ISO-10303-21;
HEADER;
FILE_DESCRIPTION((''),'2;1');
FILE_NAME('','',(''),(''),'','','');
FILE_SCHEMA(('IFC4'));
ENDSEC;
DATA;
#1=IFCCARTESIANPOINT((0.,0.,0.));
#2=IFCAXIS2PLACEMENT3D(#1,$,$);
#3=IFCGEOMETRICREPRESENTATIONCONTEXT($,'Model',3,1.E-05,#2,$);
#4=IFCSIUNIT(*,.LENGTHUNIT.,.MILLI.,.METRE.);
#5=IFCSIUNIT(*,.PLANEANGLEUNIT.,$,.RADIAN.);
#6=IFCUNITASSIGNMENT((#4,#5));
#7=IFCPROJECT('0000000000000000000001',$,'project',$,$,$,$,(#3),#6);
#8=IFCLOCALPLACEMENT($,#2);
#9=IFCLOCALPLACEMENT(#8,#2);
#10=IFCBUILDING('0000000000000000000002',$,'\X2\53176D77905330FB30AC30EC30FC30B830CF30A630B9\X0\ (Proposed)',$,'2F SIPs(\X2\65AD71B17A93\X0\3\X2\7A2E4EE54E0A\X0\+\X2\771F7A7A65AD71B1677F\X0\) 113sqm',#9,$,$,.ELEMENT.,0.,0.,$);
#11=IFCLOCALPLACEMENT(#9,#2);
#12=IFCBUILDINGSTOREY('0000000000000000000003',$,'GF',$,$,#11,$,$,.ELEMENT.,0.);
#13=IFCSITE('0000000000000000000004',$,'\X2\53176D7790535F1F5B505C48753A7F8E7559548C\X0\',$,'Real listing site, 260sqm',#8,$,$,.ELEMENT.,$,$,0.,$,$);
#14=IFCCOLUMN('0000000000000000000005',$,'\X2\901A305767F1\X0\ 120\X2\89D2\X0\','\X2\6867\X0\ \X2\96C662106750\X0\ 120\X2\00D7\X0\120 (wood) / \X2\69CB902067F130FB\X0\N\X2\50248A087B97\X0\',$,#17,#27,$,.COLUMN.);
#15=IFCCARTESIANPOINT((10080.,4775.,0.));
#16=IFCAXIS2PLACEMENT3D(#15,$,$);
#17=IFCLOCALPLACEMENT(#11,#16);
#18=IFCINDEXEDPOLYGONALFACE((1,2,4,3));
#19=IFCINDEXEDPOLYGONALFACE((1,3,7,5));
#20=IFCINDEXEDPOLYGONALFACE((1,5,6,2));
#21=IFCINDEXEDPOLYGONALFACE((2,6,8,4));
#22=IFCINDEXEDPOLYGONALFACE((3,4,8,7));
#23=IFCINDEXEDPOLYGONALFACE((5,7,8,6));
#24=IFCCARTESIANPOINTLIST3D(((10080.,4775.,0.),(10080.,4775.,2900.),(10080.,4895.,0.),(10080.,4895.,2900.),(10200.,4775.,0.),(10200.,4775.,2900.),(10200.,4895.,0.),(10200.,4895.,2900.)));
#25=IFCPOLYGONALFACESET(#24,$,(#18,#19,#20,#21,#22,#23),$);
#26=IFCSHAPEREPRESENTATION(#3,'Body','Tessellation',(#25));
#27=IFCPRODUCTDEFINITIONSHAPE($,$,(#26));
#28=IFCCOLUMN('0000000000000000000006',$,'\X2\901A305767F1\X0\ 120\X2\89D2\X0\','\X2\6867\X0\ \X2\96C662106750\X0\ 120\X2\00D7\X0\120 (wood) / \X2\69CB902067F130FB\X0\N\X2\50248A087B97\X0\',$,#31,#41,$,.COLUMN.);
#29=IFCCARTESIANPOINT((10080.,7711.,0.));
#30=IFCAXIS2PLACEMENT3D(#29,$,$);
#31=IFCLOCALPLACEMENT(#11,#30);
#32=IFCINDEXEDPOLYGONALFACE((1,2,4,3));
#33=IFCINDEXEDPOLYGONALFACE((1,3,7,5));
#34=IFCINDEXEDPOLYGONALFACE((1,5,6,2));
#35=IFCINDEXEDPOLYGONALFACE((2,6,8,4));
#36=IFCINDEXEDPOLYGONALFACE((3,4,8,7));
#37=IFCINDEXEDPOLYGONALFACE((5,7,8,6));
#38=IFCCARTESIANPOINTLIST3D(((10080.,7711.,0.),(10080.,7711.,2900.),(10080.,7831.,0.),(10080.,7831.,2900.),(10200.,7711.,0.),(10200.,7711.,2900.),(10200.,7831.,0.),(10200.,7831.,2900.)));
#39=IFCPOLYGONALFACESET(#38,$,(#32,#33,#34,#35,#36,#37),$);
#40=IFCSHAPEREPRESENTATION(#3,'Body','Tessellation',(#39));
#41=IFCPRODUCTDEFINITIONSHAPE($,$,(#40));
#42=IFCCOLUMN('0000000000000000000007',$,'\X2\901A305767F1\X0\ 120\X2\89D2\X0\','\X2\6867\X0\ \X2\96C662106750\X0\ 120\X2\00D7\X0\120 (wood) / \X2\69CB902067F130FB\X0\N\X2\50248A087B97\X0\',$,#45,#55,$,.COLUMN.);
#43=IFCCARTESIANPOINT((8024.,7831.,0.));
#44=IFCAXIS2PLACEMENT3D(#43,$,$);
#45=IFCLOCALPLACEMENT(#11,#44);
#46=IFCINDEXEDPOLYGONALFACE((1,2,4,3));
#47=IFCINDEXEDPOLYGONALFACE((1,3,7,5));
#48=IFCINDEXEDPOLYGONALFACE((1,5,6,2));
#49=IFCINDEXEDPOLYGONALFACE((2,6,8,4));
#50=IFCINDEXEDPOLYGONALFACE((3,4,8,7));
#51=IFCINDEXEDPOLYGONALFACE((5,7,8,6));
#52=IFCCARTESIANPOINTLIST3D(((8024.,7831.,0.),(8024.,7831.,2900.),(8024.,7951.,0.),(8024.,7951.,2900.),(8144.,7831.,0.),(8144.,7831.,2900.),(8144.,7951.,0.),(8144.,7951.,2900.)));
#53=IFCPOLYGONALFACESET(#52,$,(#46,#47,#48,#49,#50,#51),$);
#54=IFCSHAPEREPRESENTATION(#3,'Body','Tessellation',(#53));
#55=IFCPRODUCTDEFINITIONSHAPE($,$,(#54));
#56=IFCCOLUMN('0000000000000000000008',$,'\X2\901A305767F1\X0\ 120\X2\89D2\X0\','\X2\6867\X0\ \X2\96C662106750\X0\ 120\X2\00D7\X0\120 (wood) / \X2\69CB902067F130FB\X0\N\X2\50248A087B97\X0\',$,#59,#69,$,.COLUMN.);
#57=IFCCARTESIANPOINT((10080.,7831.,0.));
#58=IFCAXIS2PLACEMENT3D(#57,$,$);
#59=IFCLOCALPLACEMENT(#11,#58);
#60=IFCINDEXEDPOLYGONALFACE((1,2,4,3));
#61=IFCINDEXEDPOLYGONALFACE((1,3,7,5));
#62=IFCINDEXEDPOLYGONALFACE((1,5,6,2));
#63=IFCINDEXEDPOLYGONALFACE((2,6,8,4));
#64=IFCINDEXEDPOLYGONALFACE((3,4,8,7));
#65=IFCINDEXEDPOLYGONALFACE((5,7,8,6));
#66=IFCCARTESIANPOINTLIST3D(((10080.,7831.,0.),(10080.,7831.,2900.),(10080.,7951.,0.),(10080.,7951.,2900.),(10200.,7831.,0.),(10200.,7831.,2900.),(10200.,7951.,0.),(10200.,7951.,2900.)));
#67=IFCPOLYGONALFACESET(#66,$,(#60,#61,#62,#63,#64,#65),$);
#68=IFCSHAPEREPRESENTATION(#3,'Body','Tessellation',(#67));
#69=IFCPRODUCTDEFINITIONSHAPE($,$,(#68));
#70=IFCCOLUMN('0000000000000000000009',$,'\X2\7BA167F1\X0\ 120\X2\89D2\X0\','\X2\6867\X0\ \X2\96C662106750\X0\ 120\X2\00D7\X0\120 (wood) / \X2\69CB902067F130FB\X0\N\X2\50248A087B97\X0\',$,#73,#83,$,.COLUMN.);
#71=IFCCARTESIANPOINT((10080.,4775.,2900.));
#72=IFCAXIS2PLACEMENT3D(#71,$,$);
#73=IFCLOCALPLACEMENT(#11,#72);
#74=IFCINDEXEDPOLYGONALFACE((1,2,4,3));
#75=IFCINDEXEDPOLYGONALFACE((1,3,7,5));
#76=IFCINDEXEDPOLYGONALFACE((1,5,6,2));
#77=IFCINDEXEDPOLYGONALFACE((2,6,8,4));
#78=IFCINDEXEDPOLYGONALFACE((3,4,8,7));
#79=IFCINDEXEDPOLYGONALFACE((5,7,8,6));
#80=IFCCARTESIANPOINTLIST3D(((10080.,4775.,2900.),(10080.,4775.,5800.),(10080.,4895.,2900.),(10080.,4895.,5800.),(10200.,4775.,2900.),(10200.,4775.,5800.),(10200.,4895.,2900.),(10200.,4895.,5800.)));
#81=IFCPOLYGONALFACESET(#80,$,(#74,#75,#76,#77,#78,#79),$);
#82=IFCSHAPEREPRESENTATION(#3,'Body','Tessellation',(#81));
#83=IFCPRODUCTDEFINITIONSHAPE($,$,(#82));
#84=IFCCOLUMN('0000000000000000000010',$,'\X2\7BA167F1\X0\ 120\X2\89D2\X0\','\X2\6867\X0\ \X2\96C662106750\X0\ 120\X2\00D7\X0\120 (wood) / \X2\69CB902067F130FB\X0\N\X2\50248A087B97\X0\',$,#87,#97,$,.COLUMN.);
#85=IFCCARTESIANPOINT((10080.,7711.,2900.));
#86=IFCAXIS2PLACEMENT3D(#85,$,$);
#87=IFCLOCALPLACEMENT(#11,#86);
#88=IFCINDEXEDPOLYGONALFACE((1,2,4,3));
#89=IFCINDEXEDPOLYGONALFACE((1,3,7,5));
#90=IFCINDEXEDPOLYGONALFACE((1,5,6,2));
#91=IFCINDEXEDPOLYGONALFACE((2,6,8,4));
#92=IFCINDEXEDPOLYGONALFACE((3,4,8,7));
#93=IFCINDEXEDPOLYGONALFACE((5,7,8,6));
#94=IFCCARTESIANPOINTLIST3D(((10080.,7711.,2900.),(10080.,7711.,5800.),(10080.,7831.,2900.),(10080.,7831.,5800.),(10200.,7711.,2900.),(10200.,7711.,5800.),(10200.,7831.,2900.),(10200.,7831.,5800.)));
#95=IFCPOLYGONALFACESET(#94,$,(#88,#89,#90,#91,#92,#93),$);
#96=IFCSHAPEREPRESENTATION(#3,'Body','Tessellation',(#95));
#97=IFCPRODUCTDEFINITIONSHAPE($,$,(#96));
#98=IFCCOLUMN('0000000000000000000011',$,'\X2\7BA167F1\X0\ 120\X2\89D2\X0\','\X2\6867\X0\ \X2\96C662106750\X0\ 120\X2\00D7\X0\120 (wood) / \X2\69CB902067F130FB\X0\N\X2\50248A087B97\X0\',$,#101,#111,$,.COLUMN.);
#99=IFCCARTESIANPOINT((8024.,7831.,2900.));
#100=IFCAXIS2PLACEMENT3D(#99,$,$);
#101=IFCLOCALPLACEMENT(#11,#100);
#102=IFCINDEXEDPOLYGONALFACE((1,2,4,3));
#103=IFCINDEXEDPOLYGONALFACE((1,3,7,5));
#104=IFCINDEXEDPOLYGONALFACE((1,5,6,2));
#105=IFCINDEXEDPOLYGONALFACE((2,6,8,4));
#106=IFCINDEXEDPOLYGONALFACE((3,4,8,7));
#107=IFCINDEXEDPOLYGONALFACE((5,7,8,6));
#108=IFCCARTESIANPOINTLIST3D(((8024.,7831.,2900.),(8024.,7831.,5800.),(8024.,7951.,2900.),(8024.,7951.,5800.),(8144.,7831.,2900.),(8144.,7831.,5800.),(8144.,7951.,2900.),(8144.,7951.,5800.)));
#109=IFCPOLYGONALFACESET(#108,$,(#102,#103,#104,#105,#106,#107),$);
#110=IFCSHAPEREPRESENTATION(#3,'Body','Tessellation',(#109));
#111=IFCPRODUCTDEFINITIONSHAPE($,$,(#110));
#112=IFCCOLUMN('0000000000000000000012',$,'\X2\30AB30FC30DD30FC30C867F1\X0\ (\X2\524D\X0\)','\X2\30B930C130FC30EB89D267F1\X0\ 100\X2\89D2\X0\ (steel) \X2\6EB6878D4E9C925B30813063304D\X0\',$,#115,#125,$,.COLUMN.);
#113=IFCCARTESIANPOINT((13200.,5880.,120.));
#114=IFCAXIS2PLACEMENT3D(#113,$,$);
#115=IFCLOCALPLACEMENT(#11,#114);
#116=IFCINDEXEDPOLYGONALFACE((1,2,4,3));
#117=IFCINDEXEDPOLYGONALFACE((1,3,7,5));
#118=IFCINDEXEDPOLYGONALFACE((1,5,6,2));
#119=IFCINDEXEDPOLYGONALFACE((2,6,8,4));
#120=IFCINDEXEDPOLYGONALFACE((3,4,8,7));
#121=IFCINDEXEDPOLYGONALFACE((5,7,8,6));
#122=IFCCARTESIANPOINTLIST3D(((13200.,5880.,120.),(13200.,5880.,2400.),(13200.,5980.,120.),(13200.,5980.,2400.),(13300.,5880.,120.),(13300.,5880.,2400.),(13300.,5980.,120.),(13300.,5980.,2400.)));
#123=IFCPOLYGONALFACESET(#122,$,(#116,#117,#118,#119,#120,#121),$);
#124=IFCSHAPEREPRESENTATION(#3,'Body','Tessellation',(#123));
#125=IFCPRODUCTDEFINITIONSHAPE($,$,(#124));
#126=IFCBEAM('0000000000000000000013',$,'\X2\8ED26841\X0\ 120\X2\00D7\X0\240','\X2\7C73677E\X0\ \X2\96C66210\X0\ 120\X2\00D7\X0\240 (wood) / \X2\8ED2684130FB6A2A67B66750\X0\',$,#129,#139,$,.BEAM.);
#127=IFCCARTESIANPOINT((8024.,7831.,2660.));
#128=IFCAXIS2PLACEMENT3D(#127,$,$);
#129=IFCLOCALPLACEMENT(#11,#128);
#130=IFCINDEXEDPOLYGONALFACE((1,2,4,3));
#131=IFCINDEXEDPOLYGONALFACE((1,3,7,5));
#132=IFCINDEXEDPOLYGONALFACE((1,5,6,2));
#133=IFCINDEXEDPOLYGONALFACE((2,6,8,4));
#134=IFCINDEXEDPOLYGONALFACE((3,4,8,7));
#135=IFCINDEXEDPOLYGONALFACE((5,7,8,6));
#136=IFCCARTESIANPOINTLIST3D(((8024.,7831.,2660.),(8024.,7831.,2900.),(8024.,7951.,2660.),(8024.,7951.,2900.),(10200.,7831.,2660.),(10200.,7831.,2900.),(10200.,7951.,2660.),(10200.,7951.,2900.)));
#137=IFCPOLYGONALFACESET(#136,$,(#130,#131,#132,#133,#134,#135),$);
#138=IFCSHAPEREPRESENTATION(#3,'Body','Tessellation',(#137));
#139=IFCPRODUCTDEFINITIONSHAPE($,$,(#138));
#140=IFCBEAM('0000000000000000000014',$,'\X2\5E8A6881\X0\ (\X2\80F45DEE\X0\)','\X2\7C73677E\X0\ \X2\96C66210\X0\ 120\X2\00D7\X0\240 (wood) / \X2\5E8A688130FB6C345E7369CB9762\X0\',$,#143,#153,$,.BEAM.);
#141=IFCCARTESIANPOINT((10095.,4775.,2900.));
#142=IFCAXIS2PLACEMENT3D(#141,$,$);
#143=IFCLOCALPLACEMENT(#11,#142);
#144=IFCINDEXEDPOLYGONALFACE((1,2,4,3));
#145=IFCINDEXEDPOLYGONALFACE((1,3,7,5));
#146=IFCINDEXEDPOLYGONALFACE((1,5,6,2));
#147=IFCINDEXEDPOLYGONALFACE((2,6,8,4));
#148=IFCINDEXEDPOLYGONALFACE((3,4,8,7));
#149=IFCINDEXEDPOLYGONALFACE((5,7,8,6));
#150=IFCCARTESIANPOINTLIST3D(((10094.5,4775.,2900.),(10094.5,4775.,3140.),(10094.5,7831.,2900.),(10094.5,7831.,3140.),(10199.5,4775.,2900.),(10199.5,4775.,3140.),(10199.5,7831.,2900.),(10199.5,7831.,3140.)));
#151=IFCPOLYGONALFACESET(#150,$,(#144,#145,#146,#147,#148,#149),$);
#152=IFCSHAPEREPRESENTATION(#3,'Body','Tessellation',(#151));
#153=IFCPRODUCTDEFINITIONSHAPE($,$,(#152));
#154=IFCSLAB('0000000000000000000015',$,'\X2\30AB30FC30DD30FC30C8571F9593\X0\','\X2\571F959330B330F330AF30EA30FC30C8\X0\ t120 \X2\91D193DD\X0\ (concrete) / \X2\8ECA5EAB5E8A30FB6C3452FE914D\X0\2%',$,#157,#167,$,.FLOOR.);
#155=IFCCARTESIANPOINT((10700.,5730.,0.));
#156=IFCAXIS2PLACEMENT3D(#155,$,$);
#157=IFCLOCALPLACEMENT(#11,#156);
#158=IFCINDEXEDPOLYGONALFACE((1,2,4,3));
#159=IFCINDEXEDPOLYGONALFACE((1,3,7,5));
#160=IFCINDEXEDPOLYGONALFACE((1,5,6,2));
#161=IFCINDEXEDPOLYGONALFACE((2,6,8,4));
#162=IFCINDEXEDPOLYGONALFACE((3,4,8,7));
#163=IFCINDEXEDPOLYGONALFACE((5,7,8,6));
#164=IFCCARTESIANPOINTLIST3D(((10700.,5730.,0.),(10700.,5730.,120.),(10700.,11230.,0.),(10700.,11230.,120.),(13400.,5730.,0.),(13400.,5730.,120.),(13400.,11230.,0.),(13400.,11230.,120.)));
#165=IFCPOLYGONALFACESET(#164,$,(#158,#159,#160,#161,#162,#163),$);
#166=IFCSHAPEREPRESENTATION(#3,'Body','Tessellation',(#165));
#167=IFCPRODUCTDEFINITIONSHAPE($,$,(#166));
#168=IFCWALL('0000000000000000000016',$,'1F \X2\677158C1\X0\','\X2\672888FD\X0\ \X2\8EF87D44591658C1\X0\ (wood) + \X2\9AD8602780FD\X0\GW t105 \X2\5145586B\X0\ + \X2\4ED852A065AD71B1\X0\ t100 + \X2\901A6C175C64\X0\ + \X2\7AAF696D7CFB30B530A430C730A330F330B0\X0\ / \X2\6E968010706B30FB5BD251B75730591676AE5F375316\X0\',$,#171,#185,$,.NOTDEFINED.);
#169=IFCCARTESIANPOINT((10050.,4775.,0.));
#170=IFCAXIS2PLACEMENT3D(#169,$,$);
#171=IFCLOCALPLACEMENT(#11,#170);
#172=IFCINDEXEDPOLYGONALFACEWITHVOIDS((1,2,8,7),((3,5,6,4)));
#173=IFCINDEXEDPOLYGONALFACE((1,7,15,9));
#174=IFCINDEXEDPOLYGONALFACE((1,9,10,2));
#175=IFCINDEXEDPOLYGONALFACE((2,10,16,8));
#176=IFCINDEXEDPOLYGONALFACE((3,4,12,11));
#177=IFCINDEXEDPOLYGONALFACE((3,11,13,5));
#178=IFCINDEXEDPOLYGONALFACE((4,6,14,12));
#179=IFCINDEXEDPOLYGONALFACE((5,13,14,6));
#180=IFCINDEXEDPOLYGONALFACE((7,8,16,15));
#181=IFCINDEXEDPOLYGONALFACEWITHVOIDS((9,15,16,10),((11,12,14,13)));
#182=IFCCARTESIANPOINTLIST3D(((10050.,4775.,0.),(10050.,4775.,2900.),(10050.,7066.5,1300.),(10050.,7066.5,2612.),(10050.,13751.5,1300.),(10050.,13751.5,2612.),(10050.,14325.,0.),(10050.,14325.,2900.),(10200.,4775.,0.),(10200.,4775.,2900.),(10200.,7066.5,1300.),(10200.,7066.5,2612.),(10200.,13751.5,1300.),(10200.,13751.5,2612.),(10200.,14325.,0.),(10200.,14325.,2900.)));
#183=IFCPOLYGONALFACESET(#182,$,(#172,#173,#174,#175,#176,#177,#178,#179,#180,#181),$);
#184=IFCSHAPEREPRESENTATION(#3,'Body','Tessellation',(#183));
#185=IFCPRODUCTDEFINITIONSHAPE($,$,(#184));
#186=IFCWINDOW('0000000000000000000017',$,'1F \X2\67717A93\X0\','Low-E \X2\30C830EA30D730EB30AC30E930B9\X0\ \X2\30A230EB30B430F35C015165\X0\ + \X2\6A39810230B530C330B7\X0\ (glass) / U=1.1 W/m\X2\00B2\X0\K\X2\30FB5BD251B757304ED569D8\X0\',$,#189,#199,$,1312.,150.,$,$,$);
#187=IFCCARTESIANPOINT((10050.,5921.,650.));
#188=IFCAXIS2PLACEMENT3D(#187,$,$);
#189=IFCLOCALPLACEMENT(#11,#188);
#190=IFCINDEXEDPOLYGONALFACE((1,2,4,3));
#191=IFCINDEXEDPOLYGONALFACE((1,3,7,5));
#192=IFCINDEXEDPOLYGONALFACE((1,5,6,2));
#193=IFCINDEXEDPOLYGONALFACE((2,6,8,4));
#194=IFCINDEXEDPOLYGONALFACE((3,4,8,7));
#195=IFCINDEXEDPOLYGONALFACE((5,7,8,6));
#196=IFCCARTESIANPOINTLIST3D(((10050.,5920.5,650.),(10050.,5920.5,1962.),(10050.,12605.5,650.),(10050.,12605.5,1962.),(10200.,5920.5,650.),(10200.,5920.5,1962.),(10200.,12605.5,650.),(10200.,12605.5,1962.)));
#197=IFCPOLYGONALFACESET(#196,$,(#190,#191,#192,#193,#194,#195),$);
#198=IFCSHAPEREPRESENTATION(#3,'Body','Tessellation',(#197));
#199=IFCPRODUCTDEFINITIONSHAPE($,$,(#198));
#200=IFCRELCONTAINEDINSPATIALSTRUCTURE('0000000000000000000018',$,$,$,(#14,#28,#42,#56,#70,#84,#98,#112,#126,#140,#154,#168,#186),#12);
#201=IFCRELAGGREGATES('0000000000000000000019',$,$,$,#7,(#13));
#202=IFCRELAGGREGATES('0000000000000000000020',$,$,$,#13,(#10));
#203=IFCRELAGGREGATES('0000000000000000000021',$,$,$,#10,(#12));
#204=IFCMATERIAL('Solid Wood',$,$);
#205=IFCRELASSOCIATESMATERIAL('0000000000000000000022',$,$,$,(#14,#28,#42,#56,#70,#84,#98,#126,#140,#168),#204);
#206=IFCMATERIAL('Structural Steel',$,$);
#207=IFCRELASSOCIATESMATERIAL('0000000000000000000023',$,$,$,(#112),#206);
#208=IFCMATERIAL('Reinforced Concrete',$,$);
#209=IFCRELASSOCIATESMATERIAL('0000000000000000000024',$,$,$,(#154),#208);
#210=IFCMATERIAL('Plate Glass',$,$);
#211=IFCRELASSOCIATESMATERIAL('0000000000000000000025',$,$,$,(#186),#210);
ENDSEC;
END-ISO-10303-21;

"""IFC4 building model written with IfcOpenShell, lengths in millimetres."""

from ifc_helpers import new_model, si_unit, frame, frame_2d, origin, place, context, project, spatial, rectangle, extrude, material, element, fill, save


model = new_model("IFC4")

# Units and contexts
model_context = context("Model", 3, precision=1e-05, world=origin())
ifc_project = project(units=[si_unit("LENGTHUNIT", "METRE", prefix="MILLI"), si_unit("PLANEANGLEUNIT", "RADIAN")], contexts=[model_context])

# Site, building, storey
site_placement = place(None, origin())
site = spatial("IfcSite", under=ifc_project, at=site_placement, Name="北海道弟子屈町美留和", ObjectType="Real listing site, 260sqm", CompositionType="ELEMENT", RefElevation=0.0)
building_placement = place(site_placement, origin())
building = spatial("IfcBuilding", under=site, at=building_placement, Name="北海道・ガレージハウス (Proposed)", ObjectType="2F SIPs(断熱窓3種以上+真空断熱板) 113sqm", CompositionType="ELEMENT", ElevationOfRefHeight=0.0, ElevationOfTerrain=0.0)
storey_placement = place(building_placement, origin())
storey = spatial("IfcBuildingStorey", under=building, at=storey_placement, Name="GF", CompositionType="ELEMENT", Elevation=0.0)

# Columns
ifc_material_1 = material(Name="Solid Wood")
column_1_placement = place(storey_placement, frame((10080.0, 4775.0, 0.0)))
element("IfcColumn", 1, at=column_1_placement, inside=storey, material=ifc_material_1, Name="通し柱 120角", Description="桧 集成材 120×120 (wood) / 構造柱・N値計算", PredefinedType="COLUMN", context=model_context, shape_type="SweptSolid", body=[
    extrude(rectangle(XDim=120.0, YDim=120.0, at=frame_2d((60.0, 60.0))), frame((10080.0, 4775.0, 0.0)), (0.0, 0.0, 1.0), 2900.0),
])
column_2_placement = place(storey_placement, frame((10080.0, 7711.0, 0.0)))
element("IfcColumn", 2, at=column_2_placement, inside=storey, material=ifc_material_1, Name="通し柱 120角", Description="桧 集成材 120×120 (wood) / 構造柱・N値計算", PredefinedType="COLUMN", context=model_context, shape_type="SweptSolid", body=[
    extrude(rectangle(XDim=120.0, YDim=120.0, at=frame_2d((60.0, 60.0))), frame((10080.0, 7711.0, 0.0)), (0.0, 0.0, 1.0), 2900.0),
])
column_3_placement = place(storey_placement, frame((8024.0, 7831.0, 0.0)))
element("IfcColumn", 3, at=column_3_placement, inside=storey, material=ifc_material_1, Name="通し柱 120角", Description="桧 集成材 120×120 (wood) / 構造柱・N値計算", PredefinedType="COLUMN", context=model_context, shape_type="SweptSolid", body=[
    extrude(rectangle(XDim=120.0, YDim=120.0, at=frame_2d((60.0, 60.0))), frame((8024.0, 7831.0, 0.0)), (0.0, 0.0, 1.0), 2900.0),
])
column_4_placement = place(storey_placement, frame((10080.0, 7831.0, 0.0)))
element("IfcColumn", 4, at=column_4_placement, inside=storey, material=ifc_material_1, Name="通し柱 120角", Description="桧 集成材 120×120 (wood) / 構造柱・N値計算", PredefinedType="COLUMN", context=model_context, shape_type="SweptSolid", body=[
    extrude(rectangle(XDim=120.0, YDim=120.0, at=frame_2d((60.0, 60.0))), frame((10080.0, 7831.0, 0.0)), (0.0, 0.0, 1.0), 2900.0),
])
column_5_placement = place(storey_placement, frame((10080.0, 4775.0, 2900.0)))
element("IfcColumn", 5, at=column_5_placement, inside=storey, material=ifc_material_1, Name="管柱 120角", Description="桧 集成材 120×120 (wood) / 構造柱・N値計算", PredefinedType="COLUMN", context=model_context, shape_type="SweptSolid", body=[
    extrude(rectangle(XDim=120.0, YDim=120.0, at=frame_2d((60.0, 60.0))), frame((10080.0, 4775.0, 2900.0)), (0.0, 0.0, 1.0), 2900.0),
])
column_6_placement = place(storey_placement, frame((10080.0, 7711.0, 2900.0)))
element("IfcColumn", 6, at=column_6_placement, inside=storey, material=ifc_material_1, Name="管柱 120角", Description="桧 集成材 120×120 (wood) / 構造柱・N値計算", PredefinedType="COLUMN", context=model_context, shape_type="SweptSolid", body=[
    extrude(rectangle(XDim=120.0, YDim=120.0, at=frame_2d((60.0, 60.0))), frame((10080.0, 7711.0, 2900.0)), (0.0, 0.0, 1.0), 2900.0),
])
column_7_placement = place(storey_placement, frame((8024.0, 7831.0, 2900.0)))
element("IfcColumn", 7, at=column_7_placement, inside=storey, material=ifc_material_1, Name="管柱 120角", Description="桧 集成材 120×120 (wood) / 構造柱・N値計算", PredefinedType="COLUMN", context=model_context, shape_type="SweptSolid", body=[
    extrude(rectangle(XDim=120.0, YDim=120.0, at=frame_2d((60.0, 60.0))), frame((8024.0, 7831.0, 2900.0)), (0.0, 0.0, 1.0), 2900.0),
])
ifc_material_2 = material(Name="Structural Steel")
column_8_placement = place(storey_placement, frame((13200.0, 5880.0, 120.0)))
element("IfcColumn", 8, at=column_8_placement, inside=storey, material=ifc_material_2, Name="カーポート柱 (前)", Description="スチール角柱 100角 (steel) 溶融亜鉛めっき", PredefinedType="COLUMN", context=model_context, shape_type="SweptSolid", body=[
    extrude(rectangle(XDim=100.0, YDim=100.0, at=frame_2d((50.0, 50.0))), frame((13200.0, 5880.0, 120.0)), (0.0, 0.0, 1.0), 2280.0),
])

# Beams
beam_1_placement = place(storey_placement, frame((8024.0, 7831.0, 2660.0)))
element("IfcBeam", 9, at=beam_1_placement, inside=storey, material=ifc_material_1, Name="軒桁 120×240", Description="米松 集成 120×240 (wood) / 軒桁・横架材", PredefinedType="BEAM", context=model_context, shape_type="SweptSolid", body=[
    extrude(rectangle(XDim=2176.0, YDim=120.0, at=frame_2d((1088.0, 60.0))), frame((8024.0, 7831.0, 2660.0)), (0.0, 0.0, 1.0), 240.0),
])
beam_2_placement = place(storey_placement, frame((10095.0, 4775.0, 2900.0)))
element("IfcBeam", 10, at=beam_2_placement, inside=storey, material=ifc_material_1, Name="床梁 (胴差)", Description="米松 集成 120×240 (wood) / 床梁・水平構面", PredefinedType="BEAM", context=model_context, shape_type="SweptSolid", body=[
    extrude(rectangle(XDim=105.0, YDim=3056.0, at=frame_2d((52.0, 1528.0))), frame((10095.0, 4775.0, 2900.0)), (0.0, 0.0, 1.0), 240.0),
])

# Slab
ifc_material_3 = material(Name="Reinforced Concrete")
slab_placement = place(storey_placement, frame((10700.0, 5730.0, 0.0)))
element("IfcSlab", 11, at=slab_placement, inside=storey, material=ifc_material_3, Name="カーポート土間", Description="土間コンクリート t120 金鏝 (concrete) / 車庫床・水勾配2%", PredefinedType="FLOOR", context=model_context, shape_type="SweptSolid", body=[
    extrude(rectangle(XDim=2700.0, YDim=5500.0, at=frame_2d((1350.0, 2750.0))), frame((10700.0, 5730.0, 0.0)), (0.0, 0.0, 1.0), 120.0),
])

# Wall, opening, window
wall_1_placement = place(storey_placement, frame((10050.0, 4775.0, 0.0)))
wall_1 = element("IfcWall", 12, at=wall_1_placement, inside=storey, material=ifc_material_1, Name="1F 東壁", Description="木製 軸組外壁 (wood) + 高性能GW t105 充填 + 付加断熱 t100 + 通気層 + 窯業系サイディング / 準耐火・寒冷地外皮強化", PredefinedType="NOTDEFINED", context=model_context, shape_type="SweptSolid", body=[
    extrude(rectangle(XDim=150.0, YDim=9550.0, at=frame_2d((75.0, 4775.0))), frame((10050.0, 4775.0, 0.0)), (0.0, 0.0, 1.0), 2900.0),
])
opening_1_placement = place(storey_placement, frame((10050.0, 5921.0, 650.0)))
opening_1 = element("IfcOpeningElement", 13, at=opening_1_placement, cuts=wall_1, PredefinedType="NOTDEFINED", context=model_context, shape_type="SweptSolid", body=[
    extrude(rectangle(XDim=150.0, YDim=6685.0, at=frame_2d((75.0, 3342.0))), frame((10050.0, 5921.0, 650.0)), (0.0, 0.0, 1.0), 1312.0),
])
ifc_material_4 = material(Name="Plate Glass")
window_1_placement = place(storey_placement, frame((10050.0, 5921.0, 650.0)))
window_1 = element("IfcWindow", 14, at=window_1_placement, inside=storey, material=ifc_material_4, Name="1F 東窓", Description="Low-E トリプルガラス アルゴン封入 + 樹脂サッシ (glass) / U=1.1 W/m²K・寒冷地仕様", OverallHeight=1312.0, OverallWidth=150.0, context=model_context, shape_type="SweptSolid", body=[
    extrude(rectangle(XDim=150.0, YDim=6685.0, at=frame_2d((75.0, 3342.0))), frame((10050.0, 5921.0, 650.0)), (0.0, 0.0, 1.0), 1312.0),
])
fill(opening_1, window_1)

save(model, "model.ifc")
